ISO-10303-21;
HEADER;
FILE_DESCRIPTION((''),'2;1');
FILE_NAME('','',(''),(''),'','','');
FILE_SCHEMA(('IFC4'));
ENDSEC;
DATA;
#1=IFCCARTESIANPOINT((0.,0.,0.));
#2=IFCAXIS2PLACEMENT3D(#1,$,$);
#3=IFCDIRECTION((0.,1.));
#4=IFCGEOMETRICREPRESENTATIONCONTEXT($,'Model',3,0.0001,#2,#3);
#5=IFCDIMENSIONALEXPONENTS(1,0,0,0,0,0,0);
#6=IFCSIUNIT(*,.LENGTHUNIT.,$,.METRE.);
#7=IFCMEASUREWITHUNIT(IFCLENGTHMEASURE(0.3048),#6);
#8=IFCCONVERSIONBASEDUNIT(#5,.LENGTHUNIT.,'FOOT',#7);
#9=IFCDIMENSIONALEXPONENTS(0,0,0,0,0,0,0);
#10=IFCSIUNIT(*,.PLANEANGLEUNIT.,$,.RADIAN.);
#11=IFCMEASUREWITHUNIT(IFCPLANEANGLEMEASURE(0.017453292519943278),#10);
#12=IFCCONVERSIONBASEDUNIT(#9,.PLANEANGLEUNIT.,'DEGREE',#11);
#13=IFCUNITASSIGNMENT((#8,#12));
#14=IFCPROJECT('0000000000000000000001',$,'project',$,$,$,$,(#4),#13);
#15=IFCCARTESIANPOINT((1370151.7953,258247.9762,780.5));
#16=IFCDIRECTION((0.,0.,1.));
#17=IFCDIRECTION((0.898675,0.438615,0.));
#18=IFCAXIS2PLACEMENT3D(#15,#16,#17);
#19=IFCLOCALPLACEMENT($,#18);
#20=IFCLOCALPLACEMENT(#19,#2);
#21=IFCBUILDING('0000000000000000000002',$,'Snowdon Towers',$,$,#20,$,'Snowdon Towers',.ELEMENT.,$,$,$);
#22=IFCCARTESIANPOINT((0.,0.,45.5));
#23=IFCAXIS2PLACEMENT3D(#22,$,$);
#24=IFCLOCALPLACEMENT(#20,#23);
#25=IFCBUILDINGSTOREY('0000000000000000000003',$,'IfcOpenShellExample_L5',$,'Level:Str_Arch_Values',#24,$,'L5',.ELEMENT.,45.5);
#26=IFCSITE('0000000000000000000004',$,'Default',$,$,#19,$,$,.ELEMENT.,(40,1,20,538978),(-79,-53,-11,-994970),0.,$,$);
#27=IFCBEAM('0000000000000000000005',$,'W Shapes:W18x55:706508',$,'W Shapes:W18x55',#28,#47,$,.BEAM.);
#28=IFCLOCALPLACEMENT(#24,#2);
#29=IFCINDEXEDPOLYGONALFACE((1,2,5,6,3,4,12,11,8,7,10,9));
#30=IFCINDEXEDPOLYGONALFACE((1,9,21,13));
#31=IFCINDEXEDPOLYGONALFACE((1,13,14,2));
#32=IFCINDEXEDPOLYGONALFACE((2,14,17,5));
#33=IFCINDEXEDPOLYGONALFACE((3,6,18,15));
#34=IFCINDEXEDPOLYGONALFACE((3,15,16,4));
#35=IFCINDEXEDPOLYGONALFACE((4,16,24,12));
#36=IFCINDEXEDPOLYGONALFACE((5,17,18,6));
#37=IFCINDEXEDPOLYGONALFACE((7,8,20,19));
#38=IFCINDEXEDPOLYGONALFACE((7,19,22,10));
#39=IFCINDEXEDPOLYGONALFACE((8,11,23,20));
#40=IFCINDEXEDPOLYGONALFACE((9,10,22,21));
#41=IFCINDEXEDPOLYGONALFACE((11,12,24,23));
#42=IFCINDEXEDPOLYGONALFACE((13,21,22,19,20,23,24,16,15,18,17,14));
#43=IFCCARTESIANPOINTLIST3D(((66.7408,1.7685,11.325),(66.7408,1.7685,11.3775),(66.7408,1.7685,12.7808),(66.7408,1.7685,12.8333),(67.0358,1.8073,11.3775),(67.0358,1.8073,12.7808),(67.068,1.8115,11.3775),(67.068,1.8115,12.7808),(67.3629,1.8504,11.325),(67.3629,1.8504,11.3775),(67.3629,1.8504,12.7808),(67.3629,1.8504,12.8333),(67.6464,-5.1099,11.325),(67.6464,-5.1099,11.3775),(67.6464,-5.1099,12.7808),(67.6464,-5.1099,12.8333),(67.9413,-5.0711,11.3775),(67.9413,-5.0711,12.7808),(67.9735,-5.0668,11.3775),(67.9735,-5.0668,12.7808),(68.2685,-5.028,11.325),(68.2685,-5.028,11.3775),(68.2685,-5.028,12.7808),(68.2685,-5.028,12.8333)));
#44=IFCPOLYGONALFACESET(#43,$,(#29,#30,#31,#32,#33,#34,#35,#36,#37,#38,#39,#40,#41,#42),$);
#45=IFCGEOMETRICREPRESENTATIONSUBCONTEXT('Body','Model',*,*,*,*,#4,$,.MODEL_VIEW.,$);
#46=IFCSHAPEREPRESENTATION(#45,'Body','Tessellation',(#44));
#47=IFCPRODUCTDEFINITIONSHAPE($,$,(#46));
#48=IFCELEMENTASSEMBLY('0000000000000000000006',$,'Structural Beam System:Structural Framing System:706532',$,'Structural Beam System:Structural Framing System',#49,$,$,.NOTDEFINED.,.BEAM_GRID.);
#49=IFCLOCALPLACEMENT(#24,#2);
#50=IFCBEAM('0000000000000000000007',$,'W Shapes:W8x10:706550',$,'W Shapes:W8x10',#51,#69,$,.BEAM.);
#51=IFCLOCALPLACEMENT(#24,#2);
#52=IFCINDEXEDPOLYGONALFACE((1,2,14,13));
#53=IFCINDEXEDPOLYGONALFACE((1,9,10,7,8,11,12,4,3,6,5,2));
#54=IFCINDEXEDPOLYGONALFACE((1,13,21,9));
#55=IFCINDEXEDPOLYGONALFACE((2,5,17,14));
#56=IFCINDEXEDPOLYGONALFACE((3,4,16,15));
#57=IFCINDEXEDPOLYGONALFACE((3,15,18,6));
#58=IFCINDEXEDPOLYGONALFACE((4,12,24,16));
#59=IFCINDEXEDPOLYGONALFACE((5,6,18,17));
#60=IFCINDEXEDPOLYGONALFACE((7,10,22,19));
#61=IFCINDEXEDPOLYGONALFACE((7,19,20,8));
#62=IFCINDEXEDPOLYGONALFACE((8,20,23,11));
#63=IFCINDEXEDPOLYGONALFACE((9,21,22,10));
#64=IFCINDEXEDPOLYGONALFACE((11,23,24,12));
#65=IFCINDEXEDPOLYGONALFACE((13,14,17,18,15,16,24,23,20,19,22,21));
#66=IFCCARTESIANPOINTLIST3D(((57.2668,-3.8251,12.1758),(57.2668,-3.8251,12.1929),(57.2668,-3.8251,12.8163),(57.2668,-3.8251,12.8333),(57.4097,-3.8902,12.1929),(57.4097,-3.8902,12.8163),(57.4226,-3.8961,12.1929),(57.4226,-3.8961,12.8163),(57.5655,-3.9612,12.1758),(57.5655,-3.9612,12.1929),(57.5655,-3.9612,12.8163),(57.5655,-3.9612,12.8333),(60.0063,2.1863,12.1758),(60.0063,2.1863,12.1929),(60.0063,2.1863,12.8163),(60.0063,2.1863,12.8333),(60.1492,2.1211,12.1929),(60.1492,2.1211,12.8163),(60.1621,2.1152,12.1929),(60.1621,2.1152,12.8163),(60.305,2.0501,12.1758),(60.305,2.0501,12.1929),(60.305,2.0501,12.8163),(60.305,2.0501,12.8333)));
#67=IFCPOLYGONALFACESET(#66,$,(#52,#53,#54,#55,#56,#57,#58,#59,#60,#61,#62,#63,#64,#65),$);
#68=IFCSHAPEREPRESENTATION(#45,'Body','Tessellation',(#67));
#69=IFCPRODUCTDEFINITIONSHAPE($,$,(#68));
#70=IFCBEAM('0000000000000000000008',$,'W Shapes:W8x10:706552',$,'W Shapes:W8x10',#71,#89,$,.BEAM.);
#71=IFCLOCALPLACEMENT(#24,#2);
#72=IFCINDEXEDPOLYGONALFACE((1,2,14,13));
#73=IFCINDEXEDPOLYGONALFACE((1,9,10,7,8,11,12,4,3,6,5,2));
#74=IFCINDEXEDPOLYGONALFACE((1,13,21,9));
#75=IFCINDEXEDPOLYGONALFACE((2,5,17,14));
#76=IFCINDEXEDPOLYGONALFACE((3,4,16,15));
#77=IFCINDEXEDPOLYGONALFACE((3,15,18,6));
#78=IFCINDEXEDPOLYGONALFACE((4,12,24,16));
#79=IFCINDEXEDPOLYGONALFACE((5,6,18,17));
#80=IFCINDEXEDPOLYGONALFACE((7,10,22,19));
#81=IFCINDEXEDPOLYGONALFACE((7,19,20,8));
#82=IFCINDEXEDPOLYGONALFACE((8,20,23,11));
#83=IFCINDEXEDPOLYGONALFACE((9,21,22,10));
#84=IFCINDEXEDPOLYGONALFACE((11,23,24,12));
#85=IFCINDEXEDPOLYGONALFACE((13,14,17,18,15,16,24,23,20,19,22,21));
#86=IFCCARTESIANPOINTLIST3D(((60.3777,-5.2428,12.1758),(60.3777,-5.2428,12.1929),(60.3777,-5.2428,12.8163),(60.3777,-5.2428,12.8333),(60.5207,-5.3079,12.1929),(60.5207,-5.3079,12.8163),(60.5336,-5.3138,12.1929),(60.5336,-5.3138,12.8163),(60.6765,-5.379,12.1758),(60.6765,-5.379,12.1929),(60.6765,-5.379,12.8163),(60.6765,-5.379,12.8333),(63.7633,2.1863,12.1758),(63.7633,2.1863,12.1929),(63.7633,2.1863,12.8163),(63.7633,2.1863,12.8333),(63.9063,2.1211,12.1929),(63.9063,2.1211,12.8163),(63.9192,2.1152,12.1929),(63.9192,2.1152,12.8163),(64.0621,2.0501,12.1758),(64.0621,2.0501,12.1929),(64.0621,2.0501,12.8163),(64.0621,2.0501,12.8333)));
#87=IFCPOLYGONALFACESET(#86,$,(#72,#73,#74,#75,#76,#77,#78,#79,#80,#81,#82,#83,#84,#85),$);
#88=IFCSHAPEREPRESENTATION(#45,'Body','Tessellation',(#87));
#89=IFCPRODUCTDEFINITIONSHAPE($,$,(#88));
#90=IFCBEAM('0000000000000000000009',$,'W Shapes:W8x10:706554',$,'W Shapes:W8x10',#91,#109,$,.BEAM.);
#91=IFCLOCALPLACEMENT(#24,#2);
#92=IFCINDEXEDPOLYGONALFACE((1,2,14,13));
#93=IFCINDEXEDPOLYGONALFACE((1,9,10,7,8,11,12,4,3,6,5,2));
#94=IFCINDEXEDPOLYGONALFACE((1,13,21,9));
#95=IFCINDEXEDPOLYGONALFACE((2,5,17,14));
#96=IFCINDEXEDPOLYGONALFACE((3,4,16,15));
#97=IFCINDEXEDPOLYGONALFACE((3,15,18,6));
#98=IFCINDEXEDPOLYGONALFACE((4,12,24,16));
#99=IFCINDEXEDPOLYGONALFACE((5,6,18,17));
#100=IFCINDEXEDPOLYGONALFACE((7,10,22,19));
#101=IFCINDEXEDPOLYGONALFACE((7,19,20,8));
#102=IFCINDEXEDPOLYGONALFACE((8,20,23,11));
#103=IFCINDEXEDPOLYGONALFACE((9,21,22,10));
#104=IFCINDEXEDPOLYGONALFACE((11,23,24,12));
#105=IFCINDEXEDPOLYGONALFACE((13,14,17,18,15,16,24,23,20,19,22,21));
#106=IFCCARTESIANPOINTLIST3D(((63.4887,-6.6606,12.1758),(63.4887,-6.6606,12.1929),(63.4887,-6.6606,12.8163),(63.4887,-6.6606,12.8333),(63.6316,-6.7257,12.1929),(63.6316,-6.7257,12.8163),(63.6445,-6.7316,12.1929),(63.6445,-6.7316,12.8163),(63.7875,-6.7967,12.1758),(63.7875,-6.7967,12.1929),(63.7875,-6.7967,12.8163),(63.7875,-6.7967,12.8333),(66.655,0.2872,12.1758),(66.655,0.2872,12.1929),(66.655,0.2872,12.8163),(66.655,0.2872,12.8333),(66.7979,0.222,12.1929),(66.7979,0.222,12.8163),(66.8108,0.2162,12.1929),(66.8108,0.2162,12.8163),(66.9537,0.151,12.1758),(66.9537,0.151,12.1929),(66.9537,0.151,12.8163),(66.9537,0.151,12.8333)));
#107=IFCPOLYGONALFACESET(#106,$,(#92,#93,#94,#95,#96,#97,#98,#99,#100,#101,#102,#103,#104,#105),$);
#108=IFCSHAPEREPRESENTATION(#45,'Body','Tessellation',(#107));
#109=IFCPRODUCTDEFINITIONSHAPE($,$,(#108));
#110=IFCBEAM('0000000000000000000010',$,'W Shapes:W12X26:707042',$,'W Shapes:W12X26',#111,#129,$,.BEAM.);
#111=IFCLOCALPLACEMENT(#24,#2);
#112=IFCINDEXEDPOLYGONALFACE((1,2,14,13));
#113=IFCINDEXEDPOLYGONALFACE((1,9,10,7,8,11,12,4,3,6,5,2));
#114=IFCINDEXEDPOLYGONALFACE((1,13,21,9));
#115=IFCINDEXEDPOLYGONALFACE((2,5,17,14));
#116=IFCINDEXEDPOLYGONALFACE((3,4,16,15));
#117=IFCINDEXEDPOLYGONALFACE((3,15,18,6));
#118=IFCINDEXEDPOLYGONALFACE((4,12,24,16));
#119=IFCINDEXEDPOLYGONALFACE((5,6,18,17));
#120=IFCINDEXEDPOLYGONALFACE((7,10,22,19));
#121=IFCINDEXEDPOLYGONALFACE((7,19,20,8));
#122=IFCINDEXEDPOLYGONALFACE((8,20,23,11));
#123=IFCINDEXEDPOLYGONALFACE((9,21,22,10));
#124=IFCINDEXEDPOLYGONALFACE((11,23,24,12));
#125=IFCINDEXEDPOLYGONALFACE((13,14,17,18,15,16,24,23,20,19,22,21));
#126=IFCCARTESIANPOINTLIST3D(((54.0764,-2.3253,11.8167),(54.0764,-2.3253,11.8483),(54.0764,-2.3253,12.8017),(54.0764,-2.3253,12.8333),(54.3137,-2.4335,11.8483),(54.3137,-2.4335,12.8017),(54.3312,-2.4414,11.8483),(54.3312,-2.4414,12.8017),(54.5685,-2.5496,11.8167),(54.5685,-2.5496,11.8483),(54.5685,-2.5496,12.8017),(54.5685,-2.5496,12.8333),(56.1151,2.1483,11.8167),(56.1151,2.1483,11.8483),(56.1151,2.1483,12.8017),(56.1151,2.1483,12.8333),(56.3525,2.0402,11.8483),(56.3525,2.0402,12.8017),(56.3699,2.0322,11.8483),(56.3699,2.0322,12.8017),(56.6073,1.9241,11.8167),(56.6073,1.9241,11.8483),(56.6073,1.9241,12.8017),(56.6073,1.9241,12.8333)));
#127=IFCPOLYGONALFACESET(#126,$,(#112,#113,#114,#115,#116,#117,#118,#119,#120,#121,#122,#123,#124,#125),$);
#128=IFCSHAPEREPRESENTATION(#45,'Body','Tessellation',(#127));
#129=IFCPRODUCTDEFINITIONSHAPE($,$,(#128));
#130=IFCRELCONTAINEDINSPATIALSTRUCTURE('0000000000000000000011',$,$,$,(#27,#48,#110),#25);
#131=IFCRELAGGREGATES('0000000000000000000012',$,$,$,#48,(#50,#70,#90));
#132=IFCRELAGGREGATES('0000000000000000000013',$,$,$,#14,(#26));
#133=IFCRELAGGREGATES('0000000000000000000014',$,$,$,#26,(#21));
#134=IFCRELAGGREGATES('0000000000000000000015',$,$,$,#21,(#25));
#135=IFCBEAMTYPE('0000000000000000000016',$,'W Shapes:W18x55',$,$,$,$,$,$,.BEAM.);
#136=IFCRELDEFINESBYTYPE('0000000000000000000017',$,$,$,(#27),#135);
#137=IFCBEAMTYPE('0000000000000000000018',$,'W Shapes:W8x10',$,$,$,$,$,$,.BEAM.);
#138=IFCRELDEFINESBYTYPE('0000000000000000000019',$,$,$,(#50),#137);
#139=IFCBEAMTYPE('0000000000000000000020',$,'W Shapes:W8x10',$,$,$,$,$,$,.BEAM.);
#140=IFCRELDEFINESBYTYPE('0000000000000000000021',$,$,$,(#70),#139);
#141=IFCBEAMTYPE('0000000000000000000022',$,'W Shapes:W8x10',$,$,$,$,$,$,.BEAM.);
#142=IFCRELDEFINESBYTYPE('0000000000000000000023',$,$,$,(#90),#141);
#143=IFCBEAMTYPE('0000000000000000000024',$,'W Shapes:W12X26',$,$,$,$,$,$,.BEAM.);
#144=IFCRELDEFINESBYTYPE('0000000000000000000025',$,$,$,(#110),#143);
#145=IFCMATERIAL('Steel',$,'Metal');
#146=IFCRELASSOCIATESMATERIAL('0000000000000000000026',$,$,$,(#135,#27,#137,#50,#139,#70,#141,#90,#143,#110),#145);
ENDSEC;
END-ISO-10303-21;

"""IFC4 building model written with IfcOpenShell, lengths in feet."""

from ifc_helpers import new_model, entity, si_unit, converted_unit, direction, frame, origin, place, context, subcontext, project, spatial, indexed_curve, outline, extrude, source, transform, mapped, material, type_object, type_shapes, element, aggregate, save


model = new_model("IFC4")

# Units and contexts
model_context = context("Model", 3, precision=0.0001, world=origin(), true_north=direction((0.0, 1.0)))
body_context = subcontext(model_context, "Body", "Model", "MODEL_VIEW")
ifc_project = project(units=[converted_unit("LENGTHUNIT", "FOOT", entity("IfcLengthMeasure", 0.3048), si_unit("LENGTHUNIT", "METRE"), dimensions=[1, 0, 0, 0, 0, 0, 0]), converted_unit("PLANEANGLEUNIT", "DEGREE", entity("IfcPlaneAngleMeasure", 0.017453292519943278), si_unit("PLANEANGLEUNIT", "RADIAN"), dimensions=[0, 0, 0, 0, 0, 0, 0])], contexts=[model_context])

# Site, building, storey
site_placement = place(None, frame((1370151.7953, 258247.9762, 780.5), z_axis=(0.0, 0.0, 1.0), x_axis=(0.898675, 0.438615, 0.0)))
site = spatial("IfcSite", under=ifc_project, at=site_placement, Name="Default", CompositionType="ELEMENT", RefLatitude=(40, 1, 20, 538978), RefLongitude=(-79, -53, -11, -994970), RefElevation=0.0)
building_placement = place(site_placement, origin())
building = spatial("IfcBuilding", under=site, at=building_placement, Name="Snowdon Towers", LongName="Snowdon Towers", CompositionType="ELEMENT")
storey_placement = place(building_placement, frame((0.0, 0.0, 45.5)))
storey = spatial("IfcBuildingStorey", under=building, at=storey_placement, Name="IfcOpenShellExample_L5", ObjectType="Level:Str_Arch_Values", LongName="L5", CompositionType="ELEMENT", Elevation=45.5)

# Shared definitions
ifc_material = material(Name="Steel", Category="Metal")

# Beam
beam_type_1 = type_object("IfcBeamType", Name="W Shapes:W18x55", PredefinedType="BEAM", material=ifc_material)
shared_shape_1 = source(origin(), body_context, "Body", "SweptSolid", [
    extrude(outline(indexed_curve([(-0.3138, -0.7017), (-0.3138, -0.7542), (0.3138, -0.7542), (0.3138, -0.7017), (0.0162, -0.7017), (0.0162, 0.7017), (0.3138, 0.7017), (0.3138, 0.7542), (-0.3137, 0.7542), (-0.3137, 0.7017), (-0.0163, 0.7017), (-0.0163, -0.7017), (-0.3138, -0.7017)], self_intersect=False)), frame((-3.2872, 0.0, 0.0), z_axis=(-1.0, 0.0, 0.0), x_axis=(0.0, -1.0, 0.0)), (0.0, 0.0, -1.0), 6.9377),
])
type_shapes(beam_type_1, [shared_shape_1])
beam_1_placement = place(storey_placement, frame((67.4809, -1.4497, 12.0792), z_axis=(0.0, 0.0, 1.0), x_axis=(0.130526, -0.991445, 0.0)))
element("IfcBeam", 1, at=beam_1_placement, inside=storey, type_object=beam_type_1, material=ifc_material, Name="W Shapes:W18x55:706508", ObjectType="W Shapes:W18x55", PredefinedType="BEAM", context=body_context, shape_type="MappedRepresentation", body=[
    mapped(shared_shape_1, transform((0.0, 0.0, 0.0), scale=1.0)),
])

# Element assembly, beams
assembly_1_placement = place(storey_placement, origin())
assembly_1 = element("IfcElementAssembly", 2, at=assembly_1_placement, inside=storey, Name="Structural Beam System:Structural Framing System:706532", ObjectType="Structural Beam System:Structural Framing System", AssemblyPlace="NOTDEFINED", PredefinedType="BEAM_GRID")
beam_type_2 = type_object("IfcBeamType", Name="W Shapes:W8x10", PredefinedType="BEAM", material=ifc_material)
shared_shape_2 = source(origin(), body_context, "Body", "SweptSolid", [
    extrude(outline(indexed_curve([(-0.1642, -0.3117), (-0.1642, -0.3288), (0.1642, -0.3288), (0.1642, -0.3117), (0.0071, -0.3117), (0.0071, 0.3117), (0.1642, 0.3117), (0.1642, 0.3287), (-0.1642, 0.3287), (-0.1642, 0.3117), (-0.0071, 0.3117), (-0.0071, -0.3117), (-0.1642, -0.3117)], self_intersect=False)), frame((-3.3777, 0.0, 0.0), z_axis=(-1.0, 0.0, 0.0), x_axis=(0.0, -1.0, 0.0)), (0.0, 0.0, -1.0), 6.6061),
])
type_shapes(beam_type_2, [shared_shape_2])
beam_2_placement = place(assembly_1_placement, frame((58.8168, -0.8196, 12.5046), z_axis=(0.0, 0.0, 1.0), x_axis=(0.414693, 0.909961, 0.0)))
beam_2 = element("IfcBeam", 3, at=beam_2_placement, type_object=beam_type_2, material=ifc_material, Name="W Shapes:W8x10:706550", ObjectType="W Shapes:W8x10", PredefinedType="BEAM", context=body_context, shape_type="MappedRepresentation", body=[
    mapped(shared_shape_2, transform((0.0, 0.0, 0.0), scale=1.0)),
])
beam_type_3 = type_object("IfcBeamType", Name="W Shapes:W8x10", PredefinedType="BEAM", material=ifc_material)
shared_shape_3 = source(origin(), body_context, "Body", "SweptSolid", [
    extrude(outline(indexed_curve([(-0.1642, -0.3117), (-0.1642, -0.3288), (0.1642, -0.3288), (0.1642, -0.3117), (0.0071, -0.3117), (0.0071, 0.3117), (0.1642, 0.3117), (0.1642, 0.3287), (-0.1642, 0.3287), (-0.1642, 0.3117), (-0.0071, 0.3117), (-0.0071, -0.3117), (-0.1642, -0.3117)], self_intersect=False)), frame((-4.1567, 0.0, 0.0), z_axis=(-1.0, 0.0, 0.0), x_axis=(0.0, -1.0, 0.0)), (0.0, 0.0, -1.0), 8.1641),
])
type_shapes(beam_type_3, [shared_shape_3])
beam_3_placement = place(assembly_1_placement, frame((62.2509, -1.5285, 12.5046), z_axis=(0.0, 0.0, 1.0), x_axis=(0.414693, 0.909961, 0.0)))
beam_3 = element("IfcBeam", 4, at=beam_3_placement, type_object=beam_type_3, material=ifc_material, Name="W Shapes:W8x10:706552", ObjectType="W Shapes:W8x10", PredefinedType="BEAM", context=body_context, shape_type="MappedRepresentation", body=[
    mapped(shared_shape_3, transform((0.0, 0.0, 0.0), scale=1.0)),
])
beam_type_4 = type_object("IfcBeamType", Name="W Shapes:W8x10", PredefinedType="BEAM", material=ifc_material)
shared_shape_4 = source(origin(), body_context, "Body", "SweptSolid", [
    extrude(outline(indexed_curve([(-0.1642, -0.3117), (-0.1642, -0.3288), (0.1642, -0.3288), (0.1642, -0.3117), (0.0071, -0.3117), (0.0071, 0.3117), (0.1642, 0.3117), (0.1642, 0.3287), (-0.1642, 0.3287), (-0.1642, 0.3117), (-0.0071, 0.3117), (-0.0071, -0.3117), (-0.1642, -0.3117)], self_intersect=False)), frame((-4.1098, 0.0, 0.0), z_axis=(-1.0, 0.0, 0.0), x_axis=(0.0, -1.0, 0.0)), (0.0, 0.0, -1.0), 7.6352),
])
type_shapes(beam_type_4, [shared_shape_4])
beam_4_placement = place(assembly_1_placement, frame((65.3424, -2.9889, 12.5046), z_axis=(0.0, 0.0, 1.0), x_axis=(0.414693, 0.909961, 0.0)))
beam_4 = element("IfcBeam", 5, at=beam_4_placement, type_object=beam_type_4, material=ifc_material, Name="W Shapes:W8x10:706554", ObjectType="W Shapes:W8x10", PredefinedType="BEAM", context=body_context, shape_type="MappedRepresentation", body=[
    mapped(shared_shape_4, transform((0.0, 0.0, 0.0), scale=1.0)),
])
aggregate(assembly_1, [beam_2, beam_3, beam_4])

# Beam
beam_type_5 = type_object("IfcBeamType", Name="W Shapes:W12X26", PredefinedType="BEAM", material=ifc_material)
shared_shape_5 = source(origin(), body_context, "Body", "SweptSolid", [
    extrude(outline(indexed_curve([(-0.2704, -0.4767), (-0.2704, -0.5083), (0.2704, -0.5083), (0.2704, -0.4767), (0.0096, -0.4767), (0.0096, 0.4767), (0.2704, 0.4767), (0.2704, 0.5083), (-0.2704, 0.5083), (-0.2704, 0.4767), (-0.0096, 0.4767), (-0.0096, -0.4767), (-0.2704, -0.4767)], self_intersect=False)), frame((-2.557, 0.0, 0.0), z_axis=(-1.0, 0.0, 0.0), x_axis=(0.0, -1.0, 0.0)), (0.0, 0.0, -1.0), 4.9163),
])
type_shapes(beam_type_5, [shared_shape_5])
beam_5_placement = place(storey_placement, frame((55.3828, -0.1107, 12.325), z_axis=(0.0, 0.0, 1.0), x_axis=(0.414693, 0.909961, 0.0)))
element("IfcBeam", 6, at=beam_5_placement, inside=storey, type_object=beam_type_5, material=ifc_material, Name="W Shapes:W12X26:707042", ObjectType="W Shapes:W12X26", PredefinedType="BEAM", context=body_context, shape_type="MappedRepresentation", body=[
    mapped(shared_shape_5, transform((0.0, 0.0, 0.0), scale=1.0)),
])

save(model, "model.ifc")
